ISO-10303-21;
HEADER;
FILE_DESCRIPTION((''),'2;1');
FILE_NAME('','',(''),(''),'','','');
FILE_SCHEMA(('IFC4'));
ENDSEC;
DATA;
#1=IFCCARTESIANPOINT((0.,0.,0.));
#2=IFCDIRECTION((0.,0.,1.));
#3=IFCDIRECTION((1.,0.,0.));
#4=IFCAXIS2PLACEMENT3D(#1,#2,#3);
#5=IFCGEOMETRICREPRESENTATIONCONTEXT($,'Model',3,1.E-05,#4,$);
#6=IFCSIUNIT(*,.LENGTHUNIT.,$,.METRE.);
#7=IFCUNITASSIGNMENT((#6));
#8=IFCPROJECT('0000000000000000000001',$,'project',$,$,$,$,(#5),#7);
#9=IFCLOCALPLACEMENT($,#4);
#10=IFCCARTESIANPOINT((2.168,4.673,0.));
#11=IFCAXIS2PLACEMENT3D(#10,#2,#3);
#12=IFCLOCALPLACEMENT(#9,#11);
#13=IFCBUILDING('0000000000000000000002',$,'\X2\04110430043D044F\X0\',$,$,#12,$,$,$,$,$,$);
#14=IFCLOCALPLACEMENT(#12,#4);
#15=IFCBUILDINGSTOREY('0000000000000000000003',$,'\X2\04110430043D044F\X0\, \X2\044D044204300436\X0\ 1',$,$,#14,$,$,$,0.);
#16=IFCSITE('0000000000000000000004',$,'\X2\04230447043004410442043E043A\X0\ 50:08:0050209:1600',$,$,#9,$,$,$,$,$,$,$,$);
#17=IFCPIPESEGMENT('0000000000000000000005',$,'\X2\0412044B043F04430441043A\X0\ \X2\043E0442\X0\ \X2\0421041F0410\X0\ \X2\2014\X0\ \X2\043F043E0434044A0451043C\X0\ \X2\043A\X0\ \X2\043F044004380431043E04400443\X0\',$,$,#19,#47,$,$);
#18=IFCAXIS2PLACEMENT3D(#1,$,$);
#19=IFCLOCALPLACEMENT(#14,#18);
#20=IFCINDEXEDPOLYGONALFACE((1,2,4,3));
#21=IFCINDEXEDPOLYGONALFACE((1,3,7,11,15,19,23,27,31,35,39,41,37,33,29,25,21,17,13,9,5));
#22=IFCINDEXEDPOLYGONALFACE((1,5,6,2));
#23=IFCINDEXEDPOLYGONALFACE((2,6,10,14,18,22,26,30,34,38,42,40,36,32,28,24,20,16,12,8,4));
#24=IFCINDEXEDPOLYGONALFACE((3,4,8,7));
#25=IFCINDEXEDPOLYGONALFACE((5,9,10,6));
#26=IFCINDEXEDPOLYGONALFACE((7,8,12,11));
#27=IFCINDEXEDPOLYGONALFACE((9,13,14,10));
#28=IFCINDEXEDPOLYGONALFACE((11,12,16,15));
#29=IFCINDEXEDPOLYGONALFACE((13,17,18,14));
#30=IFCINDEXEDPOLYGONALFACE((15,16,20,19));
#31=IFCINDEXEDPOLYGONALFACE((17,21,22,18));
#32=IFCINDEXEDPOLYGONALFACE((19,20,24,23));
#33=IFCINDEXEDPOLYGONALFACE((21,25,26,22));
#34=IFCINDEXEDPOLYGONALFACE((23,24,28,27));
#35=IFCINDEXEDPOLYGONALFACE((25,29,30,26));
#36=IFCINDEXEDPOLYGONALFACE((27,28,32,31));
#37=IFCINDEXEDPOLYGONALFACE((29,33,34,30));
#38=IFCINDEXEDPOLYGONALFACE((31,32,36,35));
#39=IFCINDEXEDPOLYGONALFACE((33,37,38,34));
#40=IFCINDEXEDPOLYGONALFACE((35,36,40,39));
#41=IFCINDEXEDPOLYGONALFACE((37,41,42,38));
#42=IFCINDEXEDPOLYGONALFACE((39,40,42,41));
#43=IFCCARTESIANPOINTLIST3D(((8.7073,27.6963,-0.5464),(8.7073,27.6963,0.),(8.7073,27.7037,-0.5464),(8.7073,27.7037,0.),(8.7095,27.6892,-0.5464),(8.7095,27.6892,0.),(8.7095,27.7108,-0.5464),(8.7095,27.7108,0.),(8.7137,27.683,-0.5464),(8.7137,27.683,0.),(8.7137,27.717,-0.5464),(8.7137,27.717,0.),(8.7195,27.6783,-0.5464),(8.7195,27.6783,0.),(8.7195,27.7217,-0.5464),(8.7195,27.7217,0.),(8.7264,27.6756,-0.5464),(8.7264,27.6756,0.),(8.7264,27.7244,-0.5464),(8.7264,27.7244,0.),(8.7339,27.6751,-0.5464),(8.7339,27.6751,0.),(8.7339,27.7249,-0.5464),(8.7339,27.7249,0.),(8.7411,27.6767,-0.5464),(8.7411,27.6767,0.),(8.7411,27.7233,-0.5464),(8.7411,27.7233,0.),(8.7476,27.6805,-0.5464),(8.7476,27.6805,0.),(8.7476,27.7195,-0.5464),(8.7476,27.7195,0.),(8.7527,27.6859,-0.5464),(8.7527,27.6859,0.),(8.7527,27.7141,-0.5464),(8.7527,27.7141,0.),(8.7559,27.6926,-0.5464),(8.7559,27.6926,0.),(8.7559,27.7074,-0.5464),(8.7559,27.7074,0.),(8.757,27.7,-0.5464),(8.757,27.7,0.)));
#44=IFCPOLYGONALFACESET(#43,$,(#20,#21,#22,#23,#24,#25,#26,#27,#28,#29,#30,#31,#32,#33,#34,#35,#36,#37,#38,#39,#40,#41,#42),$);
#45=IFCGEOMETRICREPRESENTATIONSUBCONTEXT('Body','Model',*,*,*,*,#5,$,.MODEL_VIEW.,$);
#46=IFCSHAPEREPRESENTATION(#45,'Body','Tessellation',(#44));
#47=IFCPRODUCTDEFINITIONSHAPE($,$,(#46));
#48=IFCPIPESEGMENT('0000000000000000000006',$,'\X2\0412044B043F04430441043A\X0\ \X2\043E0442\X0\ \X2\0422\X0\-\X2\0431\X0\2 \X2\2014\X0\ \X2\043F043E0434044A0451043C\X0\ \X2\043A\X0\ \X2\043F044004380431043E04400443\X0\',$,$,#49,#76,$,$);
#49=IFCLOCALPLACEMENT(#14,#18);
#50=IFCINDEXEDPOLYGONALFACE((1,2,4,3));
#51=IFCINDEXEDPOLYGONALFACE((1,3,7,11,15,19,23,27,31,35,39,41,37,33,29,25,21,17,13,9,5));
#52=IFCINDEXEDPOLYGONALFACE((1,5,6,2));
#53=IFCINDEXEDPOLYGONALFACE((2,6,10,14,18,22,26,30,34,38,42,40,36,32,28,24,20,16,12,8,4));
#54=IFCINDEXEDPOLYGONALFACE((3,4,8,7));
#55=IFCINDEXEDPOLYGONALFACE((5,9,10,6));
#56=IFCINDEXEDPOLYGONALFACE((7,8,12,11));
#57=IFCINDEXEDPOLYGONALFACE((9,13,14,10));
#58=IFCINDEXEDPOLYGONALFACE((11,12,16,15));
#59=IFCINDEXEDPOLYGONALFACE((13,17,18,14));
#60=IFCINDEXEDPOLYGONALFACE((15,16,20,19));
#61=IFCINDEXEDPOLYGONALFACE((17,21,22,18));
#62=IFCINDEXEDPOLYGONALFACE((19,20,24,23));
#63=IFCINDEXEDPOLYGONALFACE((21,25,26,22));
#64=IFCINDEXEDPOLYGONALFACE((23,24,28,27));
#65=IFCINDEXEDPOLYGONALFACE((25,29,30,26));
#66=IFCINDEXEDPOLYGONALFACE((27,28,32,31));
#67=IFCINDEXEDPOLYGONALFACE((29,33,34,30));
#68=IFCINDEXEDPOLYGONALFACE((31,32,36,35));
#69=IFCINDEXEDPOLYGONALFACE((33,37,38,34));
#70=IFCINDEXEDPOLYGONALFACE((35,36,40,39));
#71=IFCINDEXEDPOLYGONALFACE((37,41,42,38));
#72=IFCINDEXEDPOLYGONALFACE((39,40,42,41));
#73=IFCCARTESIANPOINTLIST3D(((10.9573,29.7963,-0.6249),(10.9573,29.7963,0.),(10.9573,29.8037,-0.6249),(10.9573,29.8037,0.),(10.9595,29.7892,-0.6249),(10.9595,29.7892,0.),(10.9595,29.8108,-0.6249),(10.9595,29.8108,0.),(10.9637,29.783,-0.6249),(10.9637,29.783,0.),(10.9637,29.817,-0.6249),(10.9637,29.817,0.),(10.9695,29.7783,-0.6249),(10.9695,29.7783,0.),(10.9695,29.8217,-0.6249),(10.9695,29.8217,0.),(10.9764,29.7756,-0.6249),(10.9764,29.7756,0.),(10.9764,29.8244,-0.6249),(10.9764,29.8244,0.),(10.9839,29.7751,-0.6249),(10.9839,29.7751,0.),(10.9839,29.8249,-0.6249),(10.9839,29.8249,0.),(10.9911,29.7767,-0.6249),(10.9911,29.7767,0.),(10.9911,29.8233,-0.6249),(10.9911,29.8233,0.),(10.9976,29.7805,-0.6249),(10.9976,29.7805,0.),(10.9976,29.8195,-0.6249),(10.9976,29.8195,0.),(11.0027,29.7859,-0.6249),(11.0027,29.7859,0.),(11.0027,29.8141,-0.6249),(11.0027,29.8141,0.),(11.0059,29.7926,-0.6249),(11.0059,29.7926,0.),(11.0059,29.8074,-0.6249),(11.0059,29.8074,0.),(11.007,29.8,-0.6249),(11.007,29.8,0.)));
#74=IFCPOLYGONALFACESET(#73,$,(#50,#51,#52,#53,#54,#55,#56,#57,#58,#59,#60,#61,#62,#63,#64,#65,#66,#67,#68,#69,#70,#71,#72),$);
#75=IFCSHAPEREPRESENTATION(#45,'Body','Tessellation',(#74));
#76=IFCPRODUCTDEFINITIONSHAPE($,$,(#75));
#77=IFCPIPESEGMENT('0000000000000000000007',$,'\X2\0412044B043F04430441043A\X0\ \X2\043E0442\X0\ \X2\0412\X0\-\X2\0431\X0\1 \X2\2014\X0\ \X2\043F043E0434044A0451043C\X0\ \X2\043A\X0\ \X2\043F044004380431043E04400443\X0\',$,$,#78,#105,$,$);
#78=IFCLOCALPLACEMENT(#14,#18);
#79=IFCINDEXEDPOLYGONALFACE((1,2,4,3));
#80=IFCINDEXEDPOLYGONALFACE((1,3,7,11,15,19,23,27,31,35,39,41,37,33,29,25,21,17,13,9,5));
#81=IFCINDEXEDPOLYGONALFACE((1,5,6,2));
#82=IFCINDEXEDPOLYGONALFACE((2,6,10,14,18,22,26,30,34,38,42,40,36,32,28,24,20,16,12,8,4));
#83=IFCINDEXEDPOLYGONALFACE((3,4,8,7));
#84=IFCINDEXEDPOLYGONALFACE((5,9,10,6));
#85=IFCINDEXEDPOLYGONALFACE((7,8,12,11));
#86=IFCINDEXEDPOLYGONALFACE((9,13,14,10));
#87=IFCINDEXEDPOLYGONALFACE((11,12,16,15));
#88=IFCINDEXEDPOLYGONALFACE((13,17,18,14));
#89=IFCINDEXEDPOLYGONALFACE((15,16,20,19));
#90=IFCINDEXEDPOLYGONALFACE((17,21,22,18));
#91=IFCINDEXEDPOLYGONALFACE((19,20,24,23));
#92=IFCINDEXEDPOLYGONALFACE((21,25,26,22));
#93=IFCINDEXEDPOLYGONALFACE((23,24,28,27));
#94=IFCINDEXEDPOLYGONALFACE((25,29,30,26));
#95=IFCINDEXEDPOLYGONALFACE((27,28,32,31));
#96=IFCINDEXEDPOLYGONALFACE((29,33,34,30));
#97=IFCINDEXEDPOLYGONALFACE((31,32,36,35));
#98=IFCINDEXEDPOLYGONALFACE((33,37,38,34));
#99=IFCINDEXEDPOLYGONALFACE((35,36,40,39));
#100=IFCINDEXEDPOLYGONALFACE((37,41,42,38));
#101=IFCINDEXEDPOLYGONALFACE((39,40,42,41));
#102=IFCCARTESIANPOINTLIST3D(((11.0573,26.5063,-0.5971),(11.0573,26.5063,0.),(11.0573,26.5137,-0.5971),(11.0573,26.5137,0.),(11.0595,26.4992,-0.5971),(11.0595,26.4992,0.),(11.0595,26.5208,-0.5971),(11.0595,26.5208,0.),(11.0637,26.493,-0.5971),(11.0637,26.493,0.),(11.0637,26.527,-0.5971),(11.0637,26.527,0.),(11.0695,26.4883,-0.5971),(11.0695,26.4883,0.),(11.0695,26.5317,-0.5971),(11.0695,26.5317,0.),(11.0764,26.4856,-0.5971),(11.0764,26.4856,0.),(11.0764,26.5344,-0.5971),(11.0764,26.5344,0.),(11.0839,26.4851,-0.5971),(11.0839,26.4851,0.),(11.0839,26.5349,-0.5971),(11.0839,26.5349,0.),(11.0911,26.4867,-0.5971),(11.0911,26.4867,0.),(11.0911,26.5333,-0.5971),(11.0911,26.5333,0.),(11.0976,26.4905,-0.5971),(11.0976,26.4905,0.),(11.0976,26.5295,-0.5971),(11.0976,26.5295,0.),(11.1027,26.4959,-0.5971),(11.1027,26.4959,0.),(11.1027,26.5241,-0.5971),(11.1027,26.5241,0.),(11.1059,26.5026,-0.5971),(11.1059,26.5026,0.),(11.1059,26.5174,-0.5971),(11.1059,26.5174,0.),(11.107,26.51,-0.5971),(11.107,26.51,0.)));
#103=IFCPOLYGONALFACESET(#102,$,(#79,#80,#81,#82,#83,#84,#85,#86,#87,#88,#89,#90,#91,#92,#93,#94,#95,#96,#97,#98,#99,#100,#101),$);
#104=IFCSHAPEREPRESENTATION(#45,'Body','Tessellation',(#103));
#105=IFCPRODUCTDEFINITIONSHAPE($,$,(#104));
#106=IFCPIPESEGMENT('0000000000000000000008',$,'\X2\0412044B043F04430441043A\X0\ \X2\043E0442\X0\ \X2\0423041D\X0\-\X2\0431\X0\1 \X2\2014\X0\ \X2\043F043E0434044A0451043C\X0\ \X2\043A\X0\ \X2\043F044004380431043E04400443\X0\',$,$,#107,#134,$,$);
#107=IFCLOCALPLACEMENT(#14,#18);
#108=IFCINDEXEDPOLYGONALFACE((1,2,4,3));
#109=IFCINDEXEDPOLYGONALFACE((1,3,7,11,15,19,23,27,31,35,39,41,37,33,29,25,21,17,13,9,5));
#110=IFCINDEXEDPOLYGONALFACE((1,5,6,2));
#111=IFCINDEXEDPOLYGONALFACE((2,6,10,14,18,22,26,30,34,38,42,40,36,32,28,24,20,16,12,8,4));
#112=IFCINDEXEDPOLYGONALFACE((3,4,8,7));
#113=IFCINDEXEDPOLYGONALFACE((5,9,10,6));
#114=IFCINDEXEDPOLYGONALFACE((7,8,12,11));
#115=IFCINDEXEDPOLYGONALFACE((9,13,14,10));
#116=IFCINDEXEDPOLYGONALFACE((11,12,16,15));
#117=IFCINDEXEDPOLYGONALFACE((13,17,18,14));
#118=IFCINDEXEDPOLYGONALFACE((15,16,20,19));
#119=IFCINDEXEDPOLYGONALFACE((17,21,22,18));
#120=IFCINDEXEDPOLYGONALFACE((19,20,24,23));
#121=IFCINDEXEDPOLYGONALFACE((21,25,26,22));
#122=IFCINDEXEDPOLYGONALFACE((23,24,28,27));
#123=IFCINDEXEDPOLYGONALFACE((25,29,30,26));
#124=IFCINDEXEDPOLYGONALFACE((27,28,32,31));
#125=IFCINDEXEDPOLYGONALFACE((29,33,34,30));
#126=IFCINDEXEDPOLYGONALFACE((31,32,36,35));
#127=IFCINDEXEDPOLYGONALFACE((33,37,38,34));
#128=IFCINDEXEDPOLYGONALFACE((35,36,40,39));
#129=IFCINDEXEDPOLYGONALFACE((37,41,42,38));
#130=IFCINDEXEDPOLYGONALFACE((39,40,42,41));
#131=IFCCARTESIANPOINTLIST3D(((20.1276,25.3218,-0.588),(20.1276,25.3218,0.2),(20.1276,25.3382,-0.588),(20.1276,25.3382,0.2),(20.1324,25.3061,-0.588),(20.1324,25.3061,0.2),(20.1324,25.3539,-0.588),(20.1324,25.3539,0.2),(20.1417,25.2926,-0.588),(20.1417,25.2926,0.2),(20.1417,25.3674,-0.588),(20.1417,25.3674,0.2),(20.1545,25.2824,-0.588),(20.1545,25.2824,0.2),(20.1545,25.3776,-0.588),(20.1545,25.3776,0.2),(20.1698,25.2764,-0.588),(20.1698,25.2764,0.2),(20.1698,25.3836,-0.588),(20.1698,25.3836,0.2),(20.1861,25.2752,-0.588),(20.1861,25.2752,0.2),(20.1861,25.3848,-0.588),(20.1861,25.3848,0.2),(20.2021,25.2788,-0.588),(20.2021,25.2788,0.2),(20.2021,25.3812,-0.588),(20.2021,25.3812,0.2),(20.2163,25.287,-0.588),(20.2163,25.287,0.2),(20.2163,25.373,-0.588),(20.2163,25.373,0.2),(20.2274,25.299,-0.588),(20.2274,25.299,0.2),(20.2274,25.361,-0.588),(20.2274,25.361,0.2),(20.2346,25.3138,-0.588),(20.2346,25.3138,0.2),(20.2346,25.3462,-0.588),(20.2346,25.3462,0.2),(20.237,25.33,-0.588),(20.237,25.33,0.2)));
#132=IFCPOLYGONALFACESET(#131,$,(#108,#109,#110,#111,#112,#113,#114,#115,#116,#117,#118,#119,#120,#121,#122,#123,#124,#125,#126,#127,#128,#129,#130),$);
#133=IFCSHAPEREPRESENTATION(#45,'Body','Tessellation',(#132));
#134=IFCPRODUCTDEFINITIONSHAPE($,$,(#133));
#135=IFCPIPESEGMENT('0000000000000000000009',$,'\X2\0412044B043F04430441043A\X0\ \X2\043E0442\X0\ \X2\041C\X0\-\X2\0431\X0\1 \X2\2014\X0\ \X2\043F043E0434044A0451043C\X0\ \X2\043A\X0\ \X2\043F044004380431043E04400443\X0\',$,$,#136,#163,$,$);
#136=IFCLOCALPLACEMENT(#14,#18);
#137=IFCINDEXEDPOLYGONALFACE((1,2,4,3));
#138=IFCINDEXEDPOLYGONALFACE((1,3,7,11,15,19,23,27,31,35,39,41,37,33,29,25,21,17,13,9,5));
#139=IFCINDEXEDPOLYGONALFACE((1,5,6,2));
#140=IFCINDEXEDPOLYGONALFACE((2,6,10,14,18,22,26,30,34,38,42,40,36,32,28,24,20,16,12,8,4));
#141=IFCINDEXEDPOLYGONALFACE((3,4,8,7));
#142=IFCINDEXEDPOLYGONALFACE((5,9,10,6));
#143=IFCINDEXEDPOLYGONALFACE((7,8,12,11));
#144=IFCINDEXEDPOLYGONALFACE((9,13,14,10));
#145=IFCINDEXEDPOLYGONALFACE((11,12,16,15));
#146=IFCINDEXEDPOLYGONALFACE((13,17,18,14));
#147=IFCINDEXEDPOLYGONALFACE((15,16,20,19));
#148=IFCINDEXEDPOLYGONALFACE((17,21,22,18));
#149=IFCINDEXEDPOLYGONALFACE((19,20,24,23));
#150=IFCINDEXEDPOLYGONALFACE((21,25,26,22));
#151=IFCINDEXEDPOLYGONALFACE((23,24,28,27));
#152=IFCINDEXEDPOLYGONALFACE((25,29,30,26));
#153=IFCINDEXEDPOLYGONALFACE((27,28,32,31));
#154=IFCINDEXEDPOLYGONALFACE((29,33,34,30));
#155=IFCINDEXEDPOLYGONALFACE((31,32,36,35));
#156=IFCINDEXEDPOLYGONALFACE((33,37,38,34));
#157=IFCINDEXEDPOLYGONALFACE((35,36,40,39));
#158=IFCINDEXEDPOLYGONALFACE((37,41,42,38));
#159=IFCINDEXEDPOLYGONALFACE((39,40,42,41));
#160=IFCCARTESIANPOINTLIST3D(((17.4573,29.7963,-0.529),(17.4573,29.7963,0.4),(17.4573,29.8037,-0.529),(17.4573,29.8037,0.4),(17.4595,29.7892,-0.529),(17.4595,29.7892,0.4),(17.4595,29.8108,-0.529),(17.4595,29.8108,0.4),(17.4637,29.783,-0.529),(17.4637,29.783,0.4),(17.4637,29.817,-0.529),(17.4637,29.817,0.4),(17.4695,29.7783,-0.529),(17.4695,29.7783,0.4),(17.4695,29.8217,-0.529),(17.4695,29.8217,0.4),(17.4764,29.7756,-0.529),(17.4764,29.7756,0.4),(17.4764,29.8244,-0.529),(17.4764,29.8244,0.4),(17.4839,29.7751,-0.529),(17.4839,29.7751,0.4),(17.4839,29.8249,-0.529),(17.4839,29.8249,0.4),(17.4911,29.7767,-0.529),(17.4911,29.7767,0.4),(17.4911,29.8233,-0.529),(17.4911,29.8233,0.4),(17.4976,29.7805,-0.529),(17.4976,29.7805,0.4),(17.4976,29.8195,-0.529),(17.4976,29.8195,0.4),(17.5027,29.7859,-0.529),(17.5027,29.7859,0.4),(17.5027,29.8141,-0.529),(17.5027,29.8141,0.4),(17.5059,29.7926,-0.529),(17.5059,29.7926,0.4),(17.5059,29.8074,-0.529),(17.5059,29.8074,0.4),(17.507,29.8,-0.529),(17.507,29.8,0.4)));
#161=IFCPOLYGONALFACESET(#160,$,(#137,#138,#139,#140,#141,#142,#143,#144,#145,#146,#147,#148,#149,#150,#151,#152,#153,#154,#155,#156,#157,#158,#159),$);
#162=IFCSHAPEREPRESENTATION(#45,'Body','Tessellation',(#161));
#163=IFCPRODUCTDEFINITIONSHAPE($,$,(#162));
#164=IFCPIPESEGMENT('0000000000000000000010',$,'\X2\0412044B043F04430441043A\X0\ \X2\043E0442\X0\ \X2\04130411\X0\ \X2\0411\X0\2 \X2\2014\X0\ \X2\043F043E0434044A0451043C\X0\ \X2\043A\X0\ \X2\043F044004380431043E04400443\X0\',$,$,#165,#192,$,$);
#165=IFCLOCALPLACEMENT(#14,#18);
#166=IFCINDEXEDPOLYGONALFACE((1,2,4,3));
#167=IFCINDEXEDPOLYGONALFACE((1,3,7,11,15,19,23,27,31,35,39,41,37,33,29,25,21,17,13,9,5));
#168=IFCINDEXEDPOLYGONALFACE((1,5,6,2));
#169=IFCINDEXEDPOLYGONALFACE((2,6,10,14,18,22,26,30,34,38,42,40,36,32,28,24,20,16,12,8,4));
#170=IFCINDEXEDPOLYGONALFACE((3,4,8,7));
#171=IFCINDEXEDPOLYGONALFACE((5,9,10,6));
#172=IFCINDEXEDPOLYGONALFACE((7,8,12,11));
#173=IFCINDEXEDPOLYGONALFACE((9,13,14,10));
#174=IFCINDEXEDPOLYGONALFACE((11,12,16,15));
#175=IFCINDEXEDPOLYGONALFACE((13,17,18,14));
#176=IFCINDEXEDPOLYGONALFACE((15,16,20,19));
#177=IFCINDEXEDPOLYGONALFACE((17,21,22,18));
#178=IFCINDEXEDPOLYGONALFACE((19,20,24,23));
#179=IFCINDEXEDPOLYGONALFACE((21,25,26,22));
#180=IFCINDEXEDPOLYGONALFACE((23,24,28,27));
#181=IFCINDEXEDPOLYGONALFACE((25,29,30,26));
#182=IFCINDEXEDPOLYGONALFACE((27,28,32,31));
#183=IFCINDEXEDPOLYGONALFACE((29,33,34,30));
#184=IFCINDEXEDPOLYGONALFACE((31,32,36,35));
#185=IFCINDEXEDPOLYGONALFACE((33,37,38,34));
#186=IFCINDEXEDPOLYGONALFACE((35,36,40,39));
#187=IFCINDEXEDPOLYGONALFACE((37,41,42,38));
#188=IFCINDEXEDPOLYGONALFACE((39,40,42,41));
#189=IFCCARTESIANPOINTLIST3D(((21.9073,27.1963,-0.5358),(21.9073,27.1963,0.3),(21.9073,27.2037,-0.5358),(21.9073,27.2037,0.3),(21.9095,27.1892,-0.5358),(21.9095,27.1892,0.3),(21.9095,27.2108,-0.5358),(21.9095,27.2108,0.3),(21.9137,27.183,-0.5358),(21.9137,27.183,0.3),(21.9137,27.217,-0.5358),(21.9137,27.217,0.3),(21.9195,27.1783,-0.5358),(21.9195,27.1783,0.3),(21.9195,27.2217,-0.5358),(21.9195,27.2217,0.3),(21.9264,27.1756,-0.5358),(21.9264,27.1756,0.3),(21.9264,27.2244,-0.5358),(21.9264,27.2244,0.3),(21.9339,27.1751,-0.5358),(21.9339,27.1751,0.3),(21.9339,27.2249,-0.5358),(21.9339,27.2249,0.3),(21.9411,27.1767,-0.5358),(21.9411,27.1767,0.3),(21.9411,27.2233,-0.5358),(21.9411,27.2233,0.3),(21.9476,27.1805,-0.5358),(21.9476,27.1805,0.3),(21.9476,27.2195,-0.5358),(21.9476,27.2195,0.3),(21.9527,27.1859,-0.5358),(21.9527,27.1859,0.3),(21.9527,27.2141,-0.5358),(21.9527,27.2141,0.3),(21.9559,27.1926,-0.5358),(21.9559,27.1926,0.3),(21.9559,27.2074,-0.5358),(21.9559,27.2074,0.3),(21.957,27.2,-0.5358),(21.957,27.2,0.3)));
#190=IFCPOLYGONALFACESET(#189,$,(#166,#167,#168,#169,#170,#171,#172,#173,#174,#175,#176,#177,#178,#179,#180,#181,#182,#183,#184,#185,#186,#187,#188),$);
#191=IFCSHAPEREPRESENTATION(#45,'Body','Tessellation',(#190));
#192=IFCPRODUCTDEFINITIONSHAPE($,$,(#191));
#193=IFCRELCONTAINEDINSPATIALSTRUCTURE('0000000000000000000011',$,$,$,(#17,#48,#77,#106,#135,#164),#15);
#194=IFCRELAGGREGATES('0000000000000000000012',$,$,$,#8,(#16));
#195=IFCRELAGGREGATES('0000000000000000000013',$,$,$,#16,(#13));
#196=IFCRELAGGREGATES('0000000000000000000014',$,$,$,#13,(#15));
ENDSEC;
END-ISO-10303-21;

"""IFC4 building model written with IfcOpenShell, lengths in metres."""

from ifc_helpers import new_model, si_unit, frame, origin_with_axes, origin_2d, place, context, subcontext, project, spatial, circle, extrude, element, save


model = new_model("IFC4")

# Units and contexts
model_context = context("Model", 3, precision=1e-05, world=origin_with_axes())
body_context = subcontext(model_context, "Body", "Model", "MODEL_VIEW")
ifc_project = project(units=[si_unit("LENGTHUNIT", "METRE")], contexts=[model_context])

# Site, building, storey
site_placement = place(None, origin_with_axes())
site = spatial("IfcSite", under=ifc_project, at=site_placement, Name="Участок 50:08:0050209:1600")
building_placement = place(site_placement, frame((2.168, 4.673, 0.0), z_axis=(0.0, 0.0, 1.0), x_axis=(1.0, 0.0, 0.0)))
building = spatial("IfcBuilding", under=site, at=building_placement, Name="Баня")
storey_placement = place(building_placement, origin_with_axes())
storey = spatial("IfcBuildingStorey", under=building, at=storey_placement, Name="Баня, этаж 1", Elevation=0.0)

# Pipe segments
pipe_segment_1_placement = place(storey_placement, origin_with_axes())
element("IfcPipeSegment", 1, at=pipe_segment_1_placement, inside=storey, Name="Выпуск от СПА — подъём к прибору", context=body_context, shape_type="SweptSolid", body=[
    extrude(circle(Radius=0.025, at=origin_2d()), frame((8.732, 27.7, 0.0), z_axis=(0.0, 0.0, -1.0), x_axis=(1.0, 0.0, 0.0)), (0.0, 0.0, 1.0), 0.5464),
])
pipe_segment_2_placement = place(storey_placement, origin_with_axes())
element("IfcPipeSegment", 2, at=pipe_segment_2_placement, inside=storey, Name="Выпуск от Т-б2 — подъём к прибору", context=body_context, shape_type="SweptSolid", body=[
    extrude(circle(Radius=0.025, at=origin_2d()), frame((10.982, 29.8, 0.0), z_axis=(0.0, 0.0, -1.0), x_axis=(1.0, 0.0, 0.0)), (0.0, 0.0, 1.0), 0.6249),
])
pipe_segment_3_placement = place(storey_placement, origin_with_axes())
element("IfcPipeSegment", 3, at=pipe_segment_3_placement, inside=storey, Name="Выпуск от В-б1 — подъём к прибору", context=body_context, shape_type="SweptSolid", body=[
    extrude(circle(Radius=0.025, at=origin_2d()), frame((11.082, 26.51, 0.0), z_axis=(0.0, 0.0, -1.0), x_axis=(1.0, 0.0, 0.0)), (0.0, 0.0, 1.0), 0.5971),
])
pipe_segment_4_placement = place(storey_placement, origin_with_axes())
element("IfcPipeSegment", 4, at=pipe_segment_4_placement, inside=storey, Name="Выпуск от УН-б1 — подъём к прибору", context=body_context, shape_type="SweptSolid", body=[
    extrude(circle(Radius=0.055, at=origin_2d()), frame((20.182, 25.33, 0.2), z_axis=(0.0, 0.0, -1.0), x_axis=(1.0, 0.0, 0.0)), (0.0, 0.0, 1.0), 0.788),
])
pipe_segment_5_placement = place(storey_placement, origin_with_axes())
element("IfcPipeSegment", 5, at=pipe_segment_5_placement, inside=storey, Name="Выпуск от М-б1 — подъём к прибору", context=body_context, shape_type="SweptSolid", body=[
    extrude(circle(Radius=0.025, at=origin_2d()), frame((17.482, 29.8, 0.4), z_axis=(0.0, 0.0, -1.0), x_axis=(1.0, 0.0, 0.0)), (0.0, 0.0, 1.0), 0.929),
])
pipe_segment_6_placement = place(storey_placement, origin_with_axes())
element("IfcPipeSegment", 6, at=pipe_segment_6_placement, inside=storey, Name="Выпуск от ГБ Б2 — подъём к прибору", context=body_context, shape_type="SweptSolid", body=[
    extrude(circle(Radius=0.025, at=origin_2d()), frame((21.932, 27.2, 0.3), z_axis=(0.0, 0.0, -1.0), x_axis=(1.0, 0.0, 0.0)), (0.0, 0.0, 1.0), 0.8358),
])

save(model, "model.ifc")
